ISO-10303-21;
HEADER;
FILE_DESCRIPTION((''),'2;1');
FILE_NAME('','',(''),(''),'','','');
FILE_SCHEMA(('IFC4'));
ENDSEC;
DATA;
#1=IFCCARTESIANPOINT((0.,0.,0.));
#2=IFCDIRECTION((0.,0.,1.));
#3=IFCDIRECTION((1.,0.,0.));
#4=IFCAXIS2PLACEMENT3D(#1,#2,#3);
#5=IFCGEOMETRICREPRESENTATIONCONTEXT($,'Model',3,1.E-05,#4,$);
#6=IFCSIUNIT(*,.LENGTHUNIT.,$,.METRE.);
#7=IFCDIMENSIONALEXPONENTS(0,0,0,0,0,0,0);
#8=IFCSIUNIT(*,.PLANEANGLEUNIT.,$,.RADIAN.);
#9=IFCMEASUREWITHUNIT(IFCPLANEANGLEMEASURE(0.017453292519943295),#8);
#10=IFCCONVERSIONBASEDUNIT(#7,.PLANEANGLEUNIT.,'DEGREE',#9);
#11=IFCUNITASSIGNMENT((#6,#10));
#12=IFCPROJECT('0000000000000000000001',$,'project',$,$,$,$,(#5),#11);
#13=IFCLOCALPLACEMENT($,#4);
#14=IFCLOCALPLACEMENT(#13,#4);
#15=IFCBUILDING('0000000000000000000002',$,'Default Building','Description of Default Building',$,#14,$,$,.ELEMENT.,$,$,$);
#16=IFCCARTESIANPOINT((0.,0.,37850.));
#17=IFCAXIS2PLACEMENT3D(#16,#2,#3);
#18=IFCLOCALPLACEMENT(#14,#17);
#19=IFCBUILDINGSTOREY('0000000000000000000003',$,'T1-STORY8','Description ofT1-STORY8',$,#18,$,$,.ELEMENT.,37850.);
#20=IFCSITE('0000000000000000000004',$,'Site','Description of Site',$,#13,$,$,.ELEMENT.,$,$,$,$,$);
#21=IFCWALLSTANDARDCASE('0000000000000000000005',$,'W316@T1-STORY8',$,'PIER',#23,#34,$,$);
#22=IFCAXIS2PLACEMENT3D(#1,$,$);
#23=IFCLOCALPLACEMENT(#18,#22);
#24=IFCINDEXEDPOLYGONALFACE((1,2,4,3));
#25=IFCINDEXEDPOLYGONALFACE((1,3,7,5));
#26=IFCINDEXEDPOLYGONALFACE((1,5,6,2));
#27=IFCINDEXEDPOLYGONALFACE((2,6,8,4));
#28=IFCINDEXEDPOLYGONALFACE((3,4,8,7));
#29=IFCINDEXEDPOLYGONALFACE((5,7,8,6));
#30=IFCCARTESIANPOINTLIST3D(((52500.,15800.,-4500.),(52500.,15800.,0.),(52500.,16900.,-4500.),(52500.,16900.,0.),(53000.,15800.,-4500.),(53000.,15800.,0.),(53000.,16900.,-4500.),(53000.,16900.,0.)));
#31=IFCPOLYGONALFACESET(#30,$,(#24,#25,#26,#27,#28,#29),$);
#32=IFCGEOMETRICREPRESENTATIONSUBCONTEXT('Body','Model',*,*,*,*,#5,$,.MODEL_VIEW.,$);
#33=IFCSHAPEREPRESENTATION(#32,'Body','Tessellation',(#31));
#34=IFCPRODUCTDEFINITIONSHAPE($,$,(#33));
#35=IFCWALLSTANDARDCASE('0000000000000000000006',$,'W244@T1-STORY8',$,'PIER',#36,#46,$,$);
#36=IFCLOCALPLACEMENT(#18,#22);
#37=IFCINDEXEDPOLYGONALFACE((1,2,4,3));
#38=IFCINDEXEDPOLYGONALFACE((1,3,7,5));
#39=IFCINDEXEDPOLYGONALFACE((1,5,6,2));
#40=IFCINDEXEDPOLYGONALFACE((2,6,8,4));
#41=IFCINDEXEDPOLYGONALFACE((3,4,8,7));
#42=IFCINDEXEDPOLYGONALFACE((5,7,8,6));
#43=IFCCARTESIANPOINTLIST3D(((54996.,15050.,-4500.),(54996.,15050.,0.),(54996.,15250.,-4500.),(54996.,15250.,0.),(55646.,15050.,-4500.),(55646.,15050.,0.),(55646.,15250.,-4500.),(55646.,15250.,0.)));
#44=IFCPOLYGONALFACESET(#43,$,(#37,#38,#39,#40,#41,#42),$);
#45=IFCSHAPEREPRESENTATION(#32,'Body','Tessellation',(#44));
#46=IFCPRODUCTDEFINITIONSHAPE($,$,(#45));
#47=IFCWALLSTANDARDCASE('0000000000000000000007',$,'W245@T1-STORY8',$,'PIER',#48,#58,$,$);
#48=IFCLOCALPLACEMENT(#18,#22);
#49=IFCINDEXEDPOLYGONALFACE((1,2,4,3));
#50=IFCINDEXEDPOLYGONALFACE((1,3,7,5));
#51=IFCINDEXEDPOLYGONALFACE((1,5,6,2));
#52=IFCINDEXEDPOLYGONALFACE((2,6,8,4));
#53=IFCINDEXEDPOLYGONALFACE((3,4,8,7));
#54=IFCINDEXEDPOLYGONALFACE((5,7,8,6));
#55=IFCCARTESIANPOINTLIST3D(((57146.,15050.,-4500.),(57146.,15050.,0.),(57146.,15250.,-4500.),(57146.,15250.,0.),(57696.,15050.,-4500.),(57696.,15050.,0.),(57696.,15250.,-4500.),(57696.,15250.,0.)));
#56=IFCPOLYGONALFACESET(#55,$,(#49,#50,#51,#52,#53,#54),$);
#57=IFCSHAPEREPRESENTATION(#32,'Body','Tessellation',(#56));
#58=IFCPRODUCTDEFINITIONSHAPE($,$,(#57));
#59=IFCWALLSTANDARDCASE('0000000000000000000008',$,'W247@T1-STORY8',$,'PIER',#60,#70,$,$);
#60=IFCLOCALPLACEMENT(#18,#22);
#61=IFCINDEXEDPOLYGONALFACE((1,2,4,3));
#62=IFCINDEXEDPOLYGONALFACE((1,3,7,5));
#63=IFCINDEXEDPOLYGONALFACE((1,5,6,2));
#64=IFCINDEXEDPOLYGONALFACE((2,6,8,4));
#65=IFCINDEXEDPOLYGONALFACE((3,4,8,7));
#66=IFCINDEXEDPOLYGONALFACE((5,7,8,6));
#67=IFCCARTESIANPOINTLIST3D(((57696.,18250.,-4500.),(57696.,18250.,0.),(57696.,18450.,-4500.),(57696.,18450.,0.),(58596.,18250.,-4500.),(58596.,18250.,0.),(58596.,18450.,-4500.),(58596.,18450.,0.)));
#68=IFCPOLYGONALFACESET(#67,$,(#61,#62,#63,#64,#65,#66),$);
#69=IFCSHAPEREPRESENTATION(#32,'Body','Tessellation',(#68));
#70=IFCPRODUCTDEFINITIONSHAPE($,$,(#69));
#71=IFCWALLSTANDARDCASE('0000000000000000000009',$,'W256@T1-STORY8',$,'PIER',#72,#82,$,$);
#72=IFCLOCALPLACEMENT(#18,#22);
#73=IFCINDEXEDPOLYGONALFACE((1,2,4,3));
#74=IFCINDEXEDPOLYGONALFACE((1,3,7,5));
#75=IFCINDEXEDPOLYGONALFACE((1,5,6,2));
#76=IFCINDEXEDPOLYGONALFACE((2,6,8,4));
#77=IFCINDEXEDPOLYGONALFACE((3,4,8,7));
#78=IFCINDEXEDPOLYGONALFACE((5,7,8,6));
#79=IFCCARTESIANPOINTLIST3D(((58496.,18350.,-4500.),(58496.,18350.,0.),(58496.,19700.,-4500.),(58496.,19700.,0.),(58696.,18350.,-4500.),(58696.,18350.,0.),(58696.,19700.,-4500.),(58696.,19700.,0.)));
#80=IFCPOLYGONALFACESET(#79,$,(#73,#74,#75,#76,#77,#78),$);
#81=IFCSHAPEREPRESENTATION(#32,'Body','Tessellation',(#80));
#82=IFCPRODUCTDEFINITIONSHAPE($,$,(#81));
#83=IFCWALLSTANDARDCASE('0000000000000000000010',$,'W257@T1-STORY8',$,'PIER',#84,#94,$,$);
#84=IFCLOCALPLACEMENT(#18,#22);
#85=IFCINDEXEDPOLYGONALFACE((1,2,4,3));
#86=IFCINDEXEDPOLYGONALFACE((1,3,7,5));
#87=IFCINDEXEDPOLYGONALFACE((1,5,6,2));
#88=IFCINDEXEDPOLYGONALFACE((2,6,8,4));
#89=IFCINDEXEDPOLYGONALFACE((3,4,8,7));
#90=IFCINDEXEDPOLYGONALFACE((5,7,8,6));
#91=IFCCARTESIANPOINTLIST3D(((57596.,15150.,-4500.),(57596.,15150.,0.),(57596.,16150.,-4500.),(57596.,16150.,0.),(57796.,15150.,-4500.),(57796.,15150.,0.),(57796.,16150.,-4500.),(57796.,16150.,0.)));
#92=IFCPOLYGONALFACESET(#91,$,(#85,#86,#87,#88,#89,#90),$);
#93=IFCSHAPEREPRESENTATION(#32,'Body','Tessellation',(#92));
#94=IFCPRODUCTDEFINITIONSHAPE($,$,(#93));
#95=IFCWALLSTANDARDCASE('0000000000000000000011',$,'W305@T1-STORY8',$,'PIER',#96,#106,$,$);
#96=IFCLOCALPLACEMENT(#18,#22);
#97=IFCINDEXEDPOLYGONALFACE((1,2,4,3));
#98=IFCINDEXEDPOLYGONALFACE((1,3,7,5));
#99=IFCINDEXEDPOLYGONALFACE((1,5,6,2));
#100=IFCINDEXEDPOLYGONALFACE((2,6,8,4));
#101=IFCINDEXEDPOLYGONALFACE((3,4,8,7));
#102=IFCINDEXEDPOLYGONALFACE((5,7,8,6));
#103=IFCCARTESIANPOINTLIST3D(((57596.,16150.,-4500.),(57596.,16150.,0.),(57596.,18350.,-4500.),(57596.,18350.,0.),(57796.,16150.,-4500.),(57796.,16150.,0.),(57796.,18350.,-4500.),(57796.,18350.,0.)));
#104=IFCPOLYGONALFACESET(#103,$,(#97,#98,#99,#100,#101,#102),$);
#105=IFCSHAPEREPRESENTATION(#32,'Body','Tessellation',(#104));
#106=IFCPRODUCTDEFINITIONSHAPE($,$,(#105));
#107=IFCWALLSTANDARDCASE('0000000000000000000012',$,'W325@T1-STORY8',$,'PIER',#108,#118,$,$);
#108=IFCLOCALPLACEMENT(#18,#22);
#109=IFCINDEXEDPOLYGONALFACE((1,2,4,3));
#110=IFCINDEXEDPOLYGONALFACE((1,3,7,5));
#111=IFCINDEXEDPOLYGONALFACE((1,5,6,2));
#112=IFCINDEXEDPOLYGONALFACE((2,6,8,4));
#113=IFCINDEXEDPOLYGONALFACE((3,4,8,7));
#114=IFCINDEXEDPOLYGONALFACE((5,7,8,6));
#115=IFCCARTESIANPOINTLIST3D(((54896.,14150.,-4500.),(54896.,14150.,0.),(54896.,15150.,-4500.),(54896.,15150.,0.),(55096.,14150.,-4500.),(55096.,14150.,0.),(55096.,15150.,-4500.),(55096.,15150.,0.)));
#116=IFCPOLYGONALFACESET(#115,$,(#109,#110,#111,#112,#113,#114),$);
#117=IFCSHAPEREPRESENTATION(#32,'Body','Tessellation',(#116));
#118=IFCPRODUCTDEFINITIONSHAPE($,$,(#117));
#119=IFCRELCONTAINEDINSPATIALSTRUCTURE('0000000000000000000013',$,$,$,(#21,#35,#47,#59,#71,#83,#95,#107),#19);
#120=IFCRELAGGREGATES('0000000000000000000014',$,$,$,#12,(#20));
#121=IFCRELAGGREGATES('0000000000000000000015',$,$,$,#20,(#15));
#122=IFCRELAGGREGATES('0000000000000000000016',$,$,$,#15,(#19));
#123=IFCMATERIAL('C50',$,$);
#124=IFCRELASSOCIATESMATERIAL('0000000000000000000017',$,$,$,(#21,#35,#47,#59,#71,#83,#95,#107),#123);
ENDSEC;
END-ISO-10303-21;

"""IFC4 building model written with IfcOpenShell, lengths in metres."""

from ifc_helpers import new_model, entity, si_unit, converted_unit, frame, origin_with_axes, place, context, subcontext, project, spatial, indexed_curve, outline, extrude, material, element, save


model = new_model("IFC4")

# Units and contexts
model_context = context("Model", 3, precision=1e-05, world=origin_with_axes())
body_context = subcontext(model_context, "Body", "Model", "MODEL_VIEW")
ifc_project = project(units=[si_unit("LENGTHUNIT", "METRE"), converted_unit("PLANEANGLEUNIT", "DEGREE", entity("IfcPlaneAngleMeasure", 0.017453292519943295), si_unit("PLANEANGLEUNIT", "RADIAN"), dimensions=[0, 0, 0, 0, 0, 0, 0])], contexts=[model_context])

# Site, building, storey
site_placement = place(None, origin_with_axes())
site = spatial("IfcSite", under=ifc_project, at=site_placement, Name="Site", Description="Description of Site", CompositionType="ELEMENT")
building_placement = place(site_placement, origin_with_axes())
building = spatial("IfcBuilding", under=site, at=building_placement, Name="Default Building", Description="Description of Default Building", CompositionType="ELEMENT")
storey_placement = place(building_placement, frame((0.0, 0.0, 37850.0), z_axis=(0.0, 0.0, 1.0), x_axis=(1.0, 0.0, 0.0)))
storey = spatial("IfcBuildingStorey", under=building, at=storey_placement, Name="T1-STORY8", Description="Description ofT1-STORY8", CompositionType="ELEMENT", Elevation=37850.0)

# Shared definitions
ifc_material_1 = material(Name="C50")

# Walls
wall_1_placement = place(storey_placement, frame((52750.0, 15800.0, -4500.0), z_axis=(0.0, 0.0, 1.0), x_axis=(0.0, 1.0, 0.0)))
element("IfcWallStandardCase", 1, at=wall_1_placement, inside=storey, material=ifc_material_1, Name="W316@T1-STORY8", ObjectType="PIER", context=body_context, shape_type="SweptSolid", body=[
    extrude(outline(indexed_curve([(0.0, -250.0), (0.0, 250.0), (1100.0, 250.0), (1100.0, -250.0), (0.0, -250.0)], self_intersect=False)), origin_with_axes(), (0.0, 0.0, 1.0), 4500.0),
])
wall_2_placement = place(storey_placement, frame((54996.0, 15150.0, -4500.0), z_axis=(0.0, 0.0, 1.0), x_axis=(1.0, 0.0, 0.0)))
element("IfcWallStandardCase", 2, at=wall_2_placement, inside=storey, material=ifc_material_1, Name="W244@T1-STORY8", ObjectType="PIER", context=body_context, shape_type="SweptSolid", body=[
    extrude(outline(indexed_curve([(0.0, -100.0), (0.0, 100.0), (650.0, 100.0), (650.0, -100.0), (0.0, -100.0)], self_intersect=False)), origin_with_axes(), (0.0, 0.0, 1.0), 4500.0),
])
wall_3_placement = place(storey_placement, frame((57146.0, 15150.0, -4500.0), z_axis=(0.0, 0.0, 1.0), x_axis=(1.0, 0.0, 0.0)))
element("IfcWallStandardCase", 3, at=wall_3_placement, inside=storey, material=ifc_material_1, Name="W245@T1-STORY8", ObjectType="PIER", context=body_context, shape_type="SweptSolid", body=[
    extrude(outline(indexed_curve([(0.0, -100.0), (0.0, 100.0), (550.0, 100.0), (550.0, -100.0), (0.0, -100.0)], self_intersect=False)), origin_with_axes(), (0.0, 0.0, 1.0), 4500.0),
])
wall_4_placement = place(storey_placement, frame((57696.0, 18350.0, -4500.0), z_axis=(0.0, 0.0, 1.0), x_axis=(1.0, 0.0, 0.0)))
element("IfcWallStandardCase", 4, at=wall_4_placement, inside=storey, material=ifc_material_1, Name="W247@T1-STORY8", ObjectType="PIER", context=body_context, shape_type="SweptSolid", body=[
    extrude(outline(indexed_curve([(0.0, -100.0), (0.0, 100.0), (900.0, 100.0), (900.0, -100.0), (0.0, -100.0)], self_intersect=False)), origin_with_axes(), (0.0, 0.0, 1.0), 4500.0),
])
wall_5_placement = place(storey_placement, frame((58596.0, 18350.0, -4500.0), z_axis=(0.0, 0.0, 1.0), x_axis=(0.0, 1.0, 0.0)))
element("IfcWallStandardCase", 5, at=wall_5_placement, inside=storey, material=ifc_material_1, Name="W256@T1-STORY8", ObjectType="PIER", context=body_context, shape_type="SweptSolid", body=[
    extrude(outline(indexed_curve([(0.0, -100.0), (0.0, 100.0), (1350.0, 100.0), (1350.0, -100.0), (0.0, -100.0)], self_intersect=False)), origin_with_axes(), (0.0, 0.0, 1.0), 4500.0),
])
wall_6_placement = place(storey_placement, frame((57696.0, 15150.0, -4500.0), z_axis=(0.0, 0.0, 1.0), x_axis=(0.0, 1.0, 0.0)))
element("IfcWallStandardCase", 6, at=wall_6_placement, inside=storey, material=ifc_material_1, Name="W257@T1-STORY8", ObjectType="PIER", context=body_context, shape_type="SweptSolid", body=[
    extrude(outline(indexed_curve([(0.0, -100.0), (0.0, 100.0), (1000.0, 100.0), (1000.0, -100.0), (0.0, -100.0)], self_intersect=False)), origin_with_axes(), (0.0, 0.0, 1.0), 4500.0),
])
wall_7_placement = place(storey_placement, frame((57696.0, 16150.0, -4500.0), z_axis=(0.0, 0.0, 1.0), x_axis=(0.0, 1.0, 0.0)))
element("IfcWallStandardCase", 7, at=wall_7_placement, inside=storey, material=ifc_material_1, Name="W305@T1-STORY8", ObjectType="PIER", context=body_context, shape_type="SweptSolid", body=[
    extrude(outline(indexed_curve([(0.0, -100.0), (0.0, 100.0), (2200.0, 100.0), (2200.0, -100.0), (0.0, -100.0)], self_intersect=False)), origin_with_axes(), (0.0, 0.0, 1.0), 4500.0),
])
wall_8_placement = place(storey_placement, frame((54996.0, 14150.0, -4500.0), z_axis=(0.0, 0.0, 1.0), x_axis=(0.0, 1.0, 0.0)))
element("IfcWallStandardCase", 8, at=wall_8_placement, inside=storey, material=ifc_material_1, Name="W325@T1-STORY8", ObjectType="PIER", context=body_context, shape_type="SweptSolid", body=[
    extrude(outline(indexed_curve([(0.0, -100.0), (0.0, 100.0), (1000.0, 100.0), (1000.0, -100.0), (0.0, -100.0)], self_intersect=False)), origin_with_axes(), (0.0, 0.0, 1.0), 4500.0),
])

save(model, "model.ifc")
